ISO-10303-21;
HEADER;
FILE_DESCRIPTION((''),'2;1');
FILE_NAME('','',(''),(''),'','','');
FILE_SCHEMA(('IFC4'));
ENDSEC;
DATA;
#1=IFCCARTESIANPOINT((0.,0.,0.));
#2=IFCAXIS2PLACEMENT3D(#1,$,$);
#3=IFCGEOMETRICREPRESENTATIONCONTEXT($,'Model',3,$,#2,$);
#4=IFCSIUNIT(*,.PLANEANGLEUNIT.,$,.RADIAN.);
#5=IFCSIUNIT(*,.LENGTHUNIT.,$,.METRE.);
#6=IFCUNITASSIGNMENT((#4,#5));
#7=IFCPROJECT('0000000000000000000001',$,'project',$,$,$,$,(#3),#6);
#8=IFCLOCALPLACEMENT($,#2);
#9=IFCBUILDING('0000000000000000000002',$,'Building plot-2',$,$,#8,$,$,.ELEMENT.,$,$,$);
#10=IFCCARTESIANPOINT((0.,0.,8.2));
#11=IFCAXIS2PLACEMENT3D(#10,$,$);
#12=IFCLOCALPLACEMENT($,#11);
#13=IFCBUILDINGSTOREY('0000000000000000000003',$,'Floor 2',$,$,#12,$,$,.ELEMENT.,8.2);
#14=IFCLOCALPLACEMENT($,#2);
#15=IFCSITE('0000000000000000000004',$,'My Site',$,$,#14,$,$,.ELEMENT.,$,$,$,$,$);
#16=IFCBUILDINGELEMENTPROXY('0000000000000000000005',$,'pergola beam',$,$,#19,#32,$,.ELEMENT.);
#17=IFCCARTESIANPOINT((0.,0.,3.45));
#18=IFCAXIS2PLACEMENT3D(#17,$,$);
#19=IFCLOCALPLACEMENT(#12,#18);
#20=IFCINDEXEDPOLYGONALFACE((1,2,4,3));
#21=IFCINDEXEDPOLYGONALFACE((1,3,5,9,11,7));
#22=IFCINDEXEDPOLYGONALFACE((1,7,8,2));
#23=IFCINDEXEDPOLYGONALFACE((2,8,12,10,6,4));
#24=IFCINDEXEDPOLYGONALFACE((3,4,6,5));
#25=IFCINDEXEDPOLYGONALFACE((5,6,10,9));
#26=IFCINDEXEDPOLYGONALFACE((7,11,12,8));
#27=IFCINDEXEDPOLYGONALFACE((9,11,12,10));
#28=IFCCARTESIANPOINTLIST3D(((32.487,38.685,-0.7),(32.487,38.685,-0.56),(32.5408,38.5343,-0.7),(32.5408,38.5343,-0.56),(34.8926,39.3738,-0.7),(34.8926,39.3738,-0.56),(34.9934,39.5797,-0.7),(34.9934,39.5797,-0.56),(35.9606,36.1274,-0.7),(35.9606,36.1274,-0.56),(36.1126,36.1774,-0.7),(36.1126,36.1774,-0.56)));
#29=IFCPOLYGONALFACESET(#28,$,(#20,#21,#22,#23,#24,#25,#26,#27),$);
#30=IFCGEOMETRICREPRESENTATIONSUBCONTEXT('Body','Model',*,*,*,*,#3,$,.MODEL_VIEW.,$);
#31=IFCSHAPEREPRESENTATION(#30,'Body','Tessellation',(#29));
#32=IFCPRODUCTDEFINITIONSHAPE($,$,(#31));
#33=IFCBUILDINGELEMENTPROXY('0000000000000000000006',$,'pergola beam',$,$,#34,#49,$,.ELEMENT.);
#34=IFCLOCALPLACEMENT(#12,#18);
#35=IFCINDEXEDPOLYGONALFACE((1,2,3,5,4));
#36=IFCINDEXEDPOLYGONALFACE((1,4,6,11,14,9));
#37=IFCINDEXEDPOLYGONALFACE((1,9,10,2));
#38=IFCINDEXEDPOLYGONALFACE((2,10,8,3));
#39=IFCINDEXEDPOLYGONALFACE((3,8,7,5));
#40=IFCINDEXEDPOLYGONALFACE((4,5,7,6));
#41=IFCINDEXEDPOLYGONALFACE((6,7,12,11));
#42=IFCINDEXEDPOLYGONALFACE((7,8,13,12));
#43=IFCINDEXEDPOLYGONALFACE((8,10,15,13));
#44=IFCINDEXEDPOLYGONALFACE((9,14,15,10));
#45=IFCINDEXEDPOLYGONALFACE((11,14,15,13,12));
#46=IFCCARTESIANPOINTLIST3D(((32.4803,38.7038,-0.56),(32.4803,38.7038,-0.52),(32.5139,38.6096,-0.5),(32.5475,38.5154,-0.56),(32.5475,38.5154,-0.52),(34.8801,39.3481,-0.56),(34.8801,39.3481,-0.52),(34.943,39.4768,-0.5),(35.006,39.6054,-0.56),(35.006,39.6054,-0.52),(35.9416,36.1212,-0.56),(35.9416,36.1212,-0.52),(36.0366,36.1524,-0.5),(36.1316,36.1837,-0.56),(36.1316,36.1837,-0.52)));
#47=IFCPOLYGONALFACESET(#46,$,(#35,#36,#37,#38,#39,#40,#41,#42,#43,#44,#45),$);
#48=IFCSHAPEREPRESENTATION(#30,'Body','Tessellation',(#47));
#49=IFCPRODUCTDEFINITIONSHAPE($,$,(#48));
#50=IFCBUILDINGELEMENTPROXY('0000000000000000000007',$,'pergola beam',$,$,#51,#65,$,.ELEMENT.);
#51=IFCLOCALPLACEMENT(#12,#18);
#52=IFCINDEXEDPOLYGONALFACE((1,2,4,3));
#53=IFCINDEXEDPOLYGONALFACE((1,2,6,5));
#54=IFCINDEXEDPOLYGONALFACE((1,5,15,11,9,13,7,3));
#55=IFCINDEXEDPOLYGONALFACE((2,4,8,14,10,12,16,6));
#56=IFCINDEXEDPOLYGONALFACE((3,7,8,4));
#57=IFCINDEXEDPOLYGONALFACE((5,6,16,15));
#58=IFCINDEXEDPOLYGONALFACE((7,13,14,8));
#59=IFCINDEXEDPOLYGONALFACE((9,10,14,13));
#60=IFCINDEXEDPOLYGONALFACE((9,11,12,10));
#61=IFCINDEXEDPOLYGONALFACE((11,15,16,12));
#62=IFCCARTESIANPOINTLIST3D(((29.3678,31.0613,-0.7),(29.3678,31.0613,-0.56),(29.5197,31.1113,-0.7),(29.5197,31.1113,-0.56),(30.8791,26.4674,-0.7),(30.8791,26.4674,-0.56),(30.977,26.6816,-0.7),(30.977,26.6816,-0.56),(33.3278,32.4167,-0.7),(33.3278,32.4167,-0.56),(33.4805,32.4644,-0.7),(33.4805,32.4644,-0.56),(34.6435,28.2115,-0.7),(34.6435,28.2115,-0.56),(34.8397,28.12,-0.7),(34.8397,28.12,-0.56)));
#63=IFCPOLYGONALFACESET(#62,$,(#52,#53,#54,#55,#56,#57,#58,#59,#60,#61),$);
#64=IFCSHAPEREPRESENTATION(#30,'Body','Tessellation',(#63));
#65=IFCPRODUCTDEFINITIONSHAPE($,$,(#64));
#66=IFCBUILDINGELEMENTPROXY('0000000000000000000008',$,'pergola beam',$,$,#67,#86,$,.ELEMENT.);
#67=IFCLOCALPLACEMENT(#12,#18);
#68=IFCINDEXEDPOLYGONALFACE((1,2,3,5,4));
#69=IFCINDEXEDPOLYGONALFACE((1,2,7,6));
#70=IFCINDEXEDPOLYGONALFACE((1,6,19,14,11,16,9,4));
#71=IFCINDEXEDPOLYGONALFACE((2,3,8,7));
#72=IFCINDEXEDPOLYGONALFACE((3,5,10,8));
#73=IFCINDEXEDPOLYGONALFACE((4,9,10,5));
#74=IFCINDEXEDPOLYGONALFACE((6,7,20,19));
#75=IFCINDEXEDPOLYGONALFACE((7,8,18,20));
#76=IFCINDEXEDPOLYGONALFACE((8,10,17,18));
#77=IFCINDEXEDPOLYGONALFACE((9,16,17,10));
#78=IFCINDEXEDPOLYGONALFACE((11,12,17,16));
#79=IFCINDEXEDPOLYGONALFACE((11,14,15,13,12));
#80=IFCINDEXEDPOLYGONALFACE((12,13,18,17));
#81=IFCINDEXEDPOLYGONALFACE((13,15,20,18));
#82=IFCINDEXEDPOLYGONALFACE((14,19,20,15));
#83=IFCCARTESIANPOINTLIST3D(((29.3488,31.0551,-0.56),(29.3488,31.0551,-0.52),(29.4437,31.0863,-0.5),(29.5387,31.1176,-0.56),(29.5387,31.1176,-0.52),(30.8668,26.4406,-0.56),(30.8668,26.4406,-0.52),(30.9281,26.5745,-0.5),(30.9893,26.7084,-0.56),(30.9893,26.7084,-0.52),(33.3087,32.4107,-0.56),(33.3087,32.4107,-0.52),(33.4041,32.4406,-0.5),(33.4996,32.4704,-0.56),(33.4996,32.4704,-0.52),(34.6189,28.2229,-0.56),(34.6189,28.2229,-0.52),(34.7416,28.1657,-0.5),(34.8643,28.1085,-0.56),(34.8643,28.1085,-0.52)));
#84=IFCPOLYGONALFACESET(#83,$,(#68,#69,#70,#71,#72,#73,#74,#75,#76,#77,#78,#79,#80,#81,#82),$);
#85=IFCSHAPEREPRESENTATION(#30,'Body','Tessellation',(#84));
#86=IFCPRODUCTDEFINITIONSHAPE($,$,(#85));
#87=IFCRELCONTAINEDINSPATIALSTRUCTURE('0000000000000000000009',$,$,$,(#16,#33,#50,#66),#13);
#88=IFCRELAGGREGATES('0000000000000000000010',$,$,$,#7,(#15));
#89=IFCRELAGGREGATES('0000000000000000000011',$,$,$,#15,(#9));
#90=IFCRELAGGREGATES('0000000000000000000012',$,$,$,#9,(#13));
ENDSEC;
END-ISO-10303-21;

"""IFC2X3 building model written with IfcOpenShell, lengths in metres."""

from ifc_helpers import new_model, entity, si_unit, frame, origin, place, context, subcontext, project, spatial, element, save


model = new_model("IFC2X3")

# Units and contexts
model_context = context("Model", 3, world=origin())
body_context = subcontext(model_context, "Body", "Model", "MODEL_VIEW")
ifc_project = project(units=[si_unit("PLANEANGLEUNIT", "RADIAN"), si_unit("LENGTHUNIT", "METRE")], contexts=[model_context])

# Site, building, storey
site_placement = place(None, origin())
site = spatial("IfcSite", under=ifc_project, at=site_placement, Name="My Site", CompositionType="ELEMENT")
building_placement = place(None, origin())
building = spatial("IfcBuilding", under=site, at=building_placement, Name="Building plot-2", CompositionType="ELEMENT")
storey_placement = place(None, frame((0.0, 0.0, 8.2)))
storey = spatial("IfcBuildingStorey", under=building, at=storey_placement, Name="Floor 2", CompositionType="ELEMENT", Elevation=8.2)

# Building element proxies
proxy_1_placement = place(storey_placement, frame((0.0, 0.0, 3.45)))
axis2_placement3_d_1 = entity("IfcAxis2Placement3D", entity("IfcCartesianPoint", [0.0, 0.0, 0.0]))
element("IfcBuildingElementProxy", 1, at=proxy_1_placement, inside=storey, Name="pergola beam", CompositionType="ELEMENT", context=body_context, shape_type="SweptSolid", held_by="IfcProductRepresentation", body=[
    entity("IfcSurfaceCurveSweptAreaSolid", entity("IfcArbitraryClosedProfileDef", "AREA", None, entity("IfcPolyline", [entity("IfcCartesianPoint", [-0.7, -0.08]), entity("IfcCartesianPoint", [-0.7, 0.08]), entity("IfcCartesianPoint", [-0.56, 0.08]), entity("IfcCartesianPoint", [-0.56, -0.08]), entity("IfcCartesianPoint", [-0.7, -0.08])])), axis2_placement3_d_1, entity("IfcPolyline", [entity("IfcCartesianPoint", [36.0366, 36.1524]), entity("IfcCartesianPoint", [34.943, 39.4768]), entity("IfcCartesianPoint", [32.5139, 38.6096])]), 0.0, 1.0, entity("IfcPlane", axis2_placement3_d_1)),
])
proxy_2_placement = place(storey_placement, frame((0.0, 0.0, 3.45)))
axis2_placement3_d_2 = entity("IfcAxis2Placement3D", entity("IfcCartesianPoint", [0.0, 0.0, 0.0]))
element("IfcBuildingElementProxy", 2, at=proxy_2_placement, inside=storey, Name="pergola beam", CompositionType="ELEMENT", context=body_context, shape_type="SweptSolid", held_by="IfcProductRepresentation", body=[
    entity("IfcSurfaceCurveSweptAreaSolid", entity("IfcArbitraryClosedProfileDef", "AREA", None, entity("IfcPolyline", [entity("IfcCartesianPoint", [-0.5, 0.0]), entity("IfcCartesianPoint", [-0.52, -0.1]), entity("IfcCartesianPoint", [-0.56, -0.1]), entity("IfcCartesianPoint", [-0.56, 0.1]), entity("IfcCartesianPoint", [-0.52, 0.1]), entity("IfcCartesianPoint", [-0.5, 0.0])])), axis2_placement3_d_2, entity("IfcPolyline", [entity("IfcCartesianPoint", [36.0366, 36.1524]), entity("IfcCartesianPoint", [34.943, 39.4768]), entity("IfcCartesianPoint", [32.5139, 38.6096])]), 0.0, 1.0, entity("IfcPlane", axis2_placement3_d_2)),
])
proxy_3_placement = place(storey_placement, frame((0.0, 0.0, 3.45)))
axis2_placement3_d_3 = entity("IfcAxis2Placement3D", entity("IfcCartesianPoint", [0.0, 0.0, 0.0]))
element("IfcBuildingElementProxy", 3, at=proxy_3_placement, inside=storey, Name="pergola beam", CompositionType="ELEMENT", context=body_context, shape_type="SweptSolid", held_by="IfcProductRepresentation", body=[
    entity("IfcSurfaceCurveSweptAreaSolid", entity("IfcArbitraryClosedProfileDef", "AREA", None, entity("IfcPolyline", [entity("IfcCartesianPoint", [-0.7, -0.08]), entity("IfcCartesianPoint", [-0.7, 0.08]), entity("IfcCartesianPoint", [-0.56, 0.08]), entity("IfcCartesianPoint", [-0.56, -0.08]), entity("IfcCartesianPoint", [-0.7, -0.08])])), axis2_placement3_d_3, entity("IfcPolyline", [entity("IfcCartesianPoint", [29.4437, 31.0863]), entity("IfcCartesianPoint", [30.9281, 26.5745]), entity("IfcCartesianPoint", [34.7416, 28.1657]), entity("IfcCartesianPoint", [33.4041, 32.4406])]), 0.0, 1.0, entity("IfcPlane", axis2_placement3_d_3)),
])
proxy_4_placement = place(storey_placement, frame((0.0, 0.0, 3.45)))
axis2_placement3_d_4 = entity("IfcAxis2Placement3D", entity("IfcCartesianPoint", [0.0, 0.0, 0.0]))
element("IfcBuildingElementProxy", 4, at=proxy_4_placement, inside=storey, Name="pergola beam", CompositionType="ELEMENT", context=body_context, shape_type="SweptSolid", held_by="IfcProductRepresentation", body=[
    entity("IfcSurfaceCurveSweptAreaSolid", entity("IfcArbitraryClosedProfileDef", "AREA", None, entity("IfcPolyline", [entity("IfcCartesianPoint", [-0.5, 0.0]), entity("IfcCartesianPoint", [-0.52, -0.1]), entity("IfcCartesianPoint", [-0.56, -0.1]), entity("IfcCartesianPoint", [-0.56, 0.1]), entity("IfcCartesianPoint", [-0.52, 0.1]), entity("IfcCartesianPoint", [-0.5, 0.0])])), axis2_placement3_d_4, entity("IfcPolyline", [entity("IfcCartesianPoint", [29.4437, 31.0863]), entity("IfcCartesianPoint", [30.9281, 26.5745]), entity("IfcCartesianPoint", [34.7416, 28.1657]), entity("IfcCartesianPoint", [33.4041, 32.4406])]), 0.0, 1.0, entity("IfcPlane", axis2_placement3_d_4)),
])

save(model, "model.ifc")
